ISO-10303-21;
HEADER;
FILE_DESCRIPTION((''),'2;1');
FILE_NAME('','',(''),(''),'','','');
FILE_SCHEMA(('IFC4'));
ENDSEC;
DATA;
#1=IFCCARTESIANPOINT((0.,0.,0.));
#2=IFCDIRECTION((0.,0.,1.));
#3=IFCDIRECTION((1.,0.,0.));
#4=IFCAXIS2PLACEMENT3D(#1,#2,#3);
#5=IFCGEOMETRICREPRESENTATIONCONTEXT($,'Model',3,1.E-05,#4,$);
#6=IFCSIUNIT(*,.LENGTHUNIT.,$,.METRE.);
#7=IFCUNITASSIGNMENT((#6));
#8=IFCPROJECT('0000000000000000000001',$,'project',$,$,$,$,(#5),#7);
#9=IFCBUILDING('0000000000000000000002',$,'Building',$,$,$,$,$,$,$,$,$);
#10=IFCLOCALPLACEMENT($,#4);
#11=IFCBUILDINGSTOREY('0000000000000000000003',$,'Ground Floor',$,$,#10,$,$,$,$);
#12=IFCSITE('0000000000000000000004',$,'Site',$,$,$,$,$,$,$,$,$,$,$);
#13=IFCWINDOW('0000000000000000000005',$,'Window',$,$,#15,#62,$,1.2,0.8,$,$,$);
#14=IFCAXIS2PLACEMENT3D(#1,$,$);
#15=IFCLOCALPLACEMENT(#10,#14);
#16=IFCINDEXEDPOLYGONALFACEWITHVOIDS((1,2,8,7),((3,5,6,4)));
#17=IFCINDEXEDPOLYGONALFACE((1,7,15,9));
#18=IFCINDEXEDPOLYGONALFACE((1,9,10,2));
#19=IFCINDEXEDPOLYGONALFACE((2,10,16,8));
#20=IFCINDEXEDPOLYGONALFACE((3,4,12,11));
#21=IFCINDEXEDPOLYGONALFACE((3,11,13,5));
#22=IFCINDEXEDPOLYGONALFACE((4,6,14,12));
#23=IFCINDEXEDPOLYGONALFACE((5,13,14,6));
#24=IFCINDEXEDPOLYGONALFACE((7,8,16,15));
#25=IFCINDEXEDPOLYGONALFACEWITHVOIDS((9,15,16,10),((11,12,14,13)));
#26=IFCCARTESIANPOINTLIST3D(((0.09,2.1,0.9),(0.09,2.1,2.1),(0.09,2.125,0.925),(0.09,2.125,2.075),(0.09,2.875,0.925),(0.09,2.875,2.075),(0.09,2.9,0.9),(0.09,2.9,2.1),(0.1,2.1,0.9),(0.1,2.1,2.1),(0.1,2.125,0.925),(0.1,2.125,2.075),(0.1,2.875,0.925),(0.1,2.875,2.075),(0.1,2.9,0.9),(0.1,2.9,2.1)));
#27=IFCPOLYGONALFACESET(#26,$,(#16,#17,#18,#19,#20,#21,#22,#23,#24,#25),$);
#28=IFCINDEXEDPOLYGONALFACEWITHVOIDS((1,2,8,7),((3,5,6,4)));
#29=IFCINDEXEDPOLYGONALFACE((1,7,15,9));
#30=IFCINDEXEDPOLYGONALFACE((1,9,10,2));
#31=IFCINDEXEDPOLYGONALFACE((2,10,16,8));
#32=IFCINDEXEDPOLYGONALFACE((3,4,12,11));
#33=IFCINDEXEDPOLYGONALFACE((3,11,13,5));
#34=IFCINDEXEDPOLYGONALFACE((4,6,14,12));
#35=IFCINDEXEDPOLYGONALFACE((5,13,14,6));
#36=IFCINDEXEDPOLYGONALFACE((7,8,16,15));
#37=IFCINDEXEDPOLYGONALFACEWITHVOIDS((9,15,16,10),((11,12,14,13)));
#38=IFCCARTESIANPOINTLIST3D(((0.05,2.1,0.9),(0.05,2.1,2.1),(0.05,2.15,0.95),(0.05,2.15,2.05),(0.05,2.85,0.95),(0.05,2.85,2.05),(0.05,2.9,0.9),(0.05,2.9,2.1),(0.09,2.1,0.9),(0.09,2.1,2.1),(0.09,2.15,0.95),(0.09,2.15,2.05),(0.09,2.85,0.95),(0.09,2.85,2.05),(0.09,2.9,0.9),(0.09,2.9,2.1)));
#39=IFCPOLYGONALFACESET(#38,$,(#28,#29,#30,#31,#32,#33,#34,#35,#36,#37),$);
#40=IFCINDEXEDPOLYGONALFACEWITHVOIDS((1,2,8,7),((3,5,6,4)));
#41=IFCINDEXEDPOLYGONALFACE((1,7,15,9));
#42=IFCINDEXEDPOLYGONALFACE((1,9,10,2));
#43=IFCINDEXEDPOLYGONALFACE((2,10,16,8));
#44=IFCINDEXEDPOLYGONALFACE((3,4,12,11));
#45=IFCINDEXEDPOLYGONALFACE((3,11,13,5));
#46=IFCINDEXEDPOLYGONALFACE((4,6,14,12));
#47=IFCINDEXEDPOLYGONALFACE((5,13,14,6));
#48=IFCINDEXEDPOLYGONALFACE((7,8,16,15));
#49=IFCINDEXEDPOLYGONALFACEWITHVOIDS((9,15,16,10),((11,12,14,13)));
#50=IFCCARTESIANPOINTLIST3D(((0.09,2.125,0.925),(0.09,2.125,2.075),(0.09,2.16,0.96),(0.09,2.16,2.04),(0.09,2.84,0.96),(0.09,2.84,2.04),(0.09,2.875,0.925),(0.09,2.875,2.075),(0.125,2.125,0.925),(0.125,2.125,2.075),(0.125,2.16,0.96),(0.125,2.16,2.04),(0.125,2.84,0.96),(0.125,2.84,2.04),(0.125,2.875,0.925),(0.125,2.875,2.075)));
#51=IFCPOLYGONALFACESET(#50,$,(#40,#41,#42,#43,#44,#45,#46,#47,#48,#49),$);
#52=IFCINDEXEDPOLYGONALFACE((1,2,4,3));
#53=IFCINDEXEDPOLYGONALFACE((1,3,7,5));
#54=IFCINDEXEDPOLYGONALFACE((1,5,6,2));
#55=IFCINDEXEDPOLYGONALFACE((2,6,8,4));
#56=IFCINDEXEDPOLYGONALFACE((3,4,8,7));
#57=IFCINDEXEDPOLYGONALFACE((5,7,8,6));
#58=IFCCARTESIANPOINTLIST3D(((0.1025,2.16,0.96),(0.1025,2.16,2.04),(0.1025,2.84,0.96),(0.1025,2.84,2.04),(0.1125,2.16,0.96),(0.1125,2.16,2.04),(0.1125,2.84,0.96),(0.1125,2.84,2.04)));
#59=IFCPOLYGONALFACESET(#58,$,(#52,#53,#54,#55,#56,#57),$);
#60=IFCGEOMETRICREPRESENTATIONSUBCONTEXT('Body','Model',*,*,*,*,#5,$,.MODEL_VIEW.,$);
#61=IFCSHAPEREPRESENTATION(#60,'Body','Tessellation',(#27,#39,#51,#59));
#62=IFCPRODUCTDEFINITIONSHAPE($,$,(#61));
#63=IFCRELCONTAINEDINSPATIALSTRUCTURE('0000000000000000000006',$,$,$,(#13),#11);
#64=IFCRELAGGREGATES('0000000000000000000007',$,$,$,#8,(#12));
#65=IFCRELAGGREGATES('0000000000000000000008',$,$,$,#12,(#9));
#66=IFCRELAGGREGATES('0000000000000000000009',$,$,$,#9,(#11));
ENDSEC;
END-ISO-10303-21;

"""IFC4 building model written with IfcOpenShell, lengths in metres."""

from ifc_helpers import new_model, si_unit, frame, origin_with_axes, place, context, subcontext, project, spatial, line, indexed_curve, outline, extrude, element, save


model = new_model("IFC4")

# Units and contexts
model_context = context("Model", 3, precision=1e-05, world=origin_with_axes())
body_context = subcontext(model_context, "Body", "Model", "MODEL_VIEW")
ifc_project = project(units=[si_unit("LENGTHUNIT", "METRE")], contexts=[model_context])

# Site, building, storey
site = spatial("IfcSite", under=ifc_project, Name="Site")
building = spatial("IfcBuilding", under=site, Name="Building")
storey_placement = place(None, origin_with_axes())
storey = spatial("IfcBuildingStorey", under=building, at=storey_placement, Name="Ground Floor")

# Window
window_1_placement = place(storey_placement, frame((0.0, 2.9, 0.9), z_axis=(0.0, 0.0, 1.0), x_axis=(0.0, -1.0, 0.0)))
element("IfcWindow", 1, at=window_1_placement, inside=storey, Name="Window", OverallHeight=1.2, OverallWidth=0.8, context=body_context, shape_type="SweptSolid", body=[
    extrude(outline(indexed_curve([(0.0, 0.0), (0.8, 0.0), (0.8, 1.2), (0.0, 1.2)], segments=[line(1, 2, 3, 4, 1)]), holes=[indexed_curve([(0.025, 0.025), (0.775, 0.025), (0.775, 1.175), (0.025, 1.175)], segments=[line(1, 2, 3, 4, 1)])]), frame((0.0, 0.09, 0.0), z_axis=(0.0, -1.0, 0.0), x_axis=(1.0, 0.0, 0.0)), (0.0, 0.0, -1.0), 0.01),
    extrude(outline(indexed_curve([(0.0, 0.0), (0.8, 0.0), (0.8, 1.2), (0.0, 1.2)], segments=[line(1, 2, 3, 4, 1)]), holes=[indexed_curve([(0.05, 0.05), (0.75, 0.05), (0.75, 1.15), (0.05, 1.15)], segments=[line(1, 2, 3, 4, 1)])]), frame((0.0, 0.05, 0.0), z_axis=(0.0, -1.0, 0.0), x_axis=(1.0, 0.0, 0.0)), (0.0, 0.0, -1.0), 0.04),
    extrude(outline(indexed_curve([(0.0, 0.0), (0.75, 0.0), (0.75, 1.15), (0.0, 1.15)], segments=[line(1, 2, 3, 4, 1)]), holes=[indexed_curve([(0.035, 0.035), (0.715, 0.035), (0.715, 1.115), (0.035, 1.115)], segments=[line(1, 2, 3, 4, 1)])]), frame((0.025, 0.09, 0.025), z_axis=(0.0, -1.0, 0.0), x_axis=(1.0, 0.0, 0.0)), (0.0, 0.0, -1.0), 0.035),
    extrude(outline(indexed_curve([(0.035, 0.035), (0.715, 0.035), (0.715, 1.115), (0.035, 1.115)], segments=[line(1, 2, 3, 4, 1)])), frame((0.025, 0.1025, 0.025), z_axis=(0.0, -1.0, 0.0), x_axis=(1.0, 0.0, 0.0)), (0.0, 0.0, -1.0), 0.01),
])

save(model, "model.ifc")
